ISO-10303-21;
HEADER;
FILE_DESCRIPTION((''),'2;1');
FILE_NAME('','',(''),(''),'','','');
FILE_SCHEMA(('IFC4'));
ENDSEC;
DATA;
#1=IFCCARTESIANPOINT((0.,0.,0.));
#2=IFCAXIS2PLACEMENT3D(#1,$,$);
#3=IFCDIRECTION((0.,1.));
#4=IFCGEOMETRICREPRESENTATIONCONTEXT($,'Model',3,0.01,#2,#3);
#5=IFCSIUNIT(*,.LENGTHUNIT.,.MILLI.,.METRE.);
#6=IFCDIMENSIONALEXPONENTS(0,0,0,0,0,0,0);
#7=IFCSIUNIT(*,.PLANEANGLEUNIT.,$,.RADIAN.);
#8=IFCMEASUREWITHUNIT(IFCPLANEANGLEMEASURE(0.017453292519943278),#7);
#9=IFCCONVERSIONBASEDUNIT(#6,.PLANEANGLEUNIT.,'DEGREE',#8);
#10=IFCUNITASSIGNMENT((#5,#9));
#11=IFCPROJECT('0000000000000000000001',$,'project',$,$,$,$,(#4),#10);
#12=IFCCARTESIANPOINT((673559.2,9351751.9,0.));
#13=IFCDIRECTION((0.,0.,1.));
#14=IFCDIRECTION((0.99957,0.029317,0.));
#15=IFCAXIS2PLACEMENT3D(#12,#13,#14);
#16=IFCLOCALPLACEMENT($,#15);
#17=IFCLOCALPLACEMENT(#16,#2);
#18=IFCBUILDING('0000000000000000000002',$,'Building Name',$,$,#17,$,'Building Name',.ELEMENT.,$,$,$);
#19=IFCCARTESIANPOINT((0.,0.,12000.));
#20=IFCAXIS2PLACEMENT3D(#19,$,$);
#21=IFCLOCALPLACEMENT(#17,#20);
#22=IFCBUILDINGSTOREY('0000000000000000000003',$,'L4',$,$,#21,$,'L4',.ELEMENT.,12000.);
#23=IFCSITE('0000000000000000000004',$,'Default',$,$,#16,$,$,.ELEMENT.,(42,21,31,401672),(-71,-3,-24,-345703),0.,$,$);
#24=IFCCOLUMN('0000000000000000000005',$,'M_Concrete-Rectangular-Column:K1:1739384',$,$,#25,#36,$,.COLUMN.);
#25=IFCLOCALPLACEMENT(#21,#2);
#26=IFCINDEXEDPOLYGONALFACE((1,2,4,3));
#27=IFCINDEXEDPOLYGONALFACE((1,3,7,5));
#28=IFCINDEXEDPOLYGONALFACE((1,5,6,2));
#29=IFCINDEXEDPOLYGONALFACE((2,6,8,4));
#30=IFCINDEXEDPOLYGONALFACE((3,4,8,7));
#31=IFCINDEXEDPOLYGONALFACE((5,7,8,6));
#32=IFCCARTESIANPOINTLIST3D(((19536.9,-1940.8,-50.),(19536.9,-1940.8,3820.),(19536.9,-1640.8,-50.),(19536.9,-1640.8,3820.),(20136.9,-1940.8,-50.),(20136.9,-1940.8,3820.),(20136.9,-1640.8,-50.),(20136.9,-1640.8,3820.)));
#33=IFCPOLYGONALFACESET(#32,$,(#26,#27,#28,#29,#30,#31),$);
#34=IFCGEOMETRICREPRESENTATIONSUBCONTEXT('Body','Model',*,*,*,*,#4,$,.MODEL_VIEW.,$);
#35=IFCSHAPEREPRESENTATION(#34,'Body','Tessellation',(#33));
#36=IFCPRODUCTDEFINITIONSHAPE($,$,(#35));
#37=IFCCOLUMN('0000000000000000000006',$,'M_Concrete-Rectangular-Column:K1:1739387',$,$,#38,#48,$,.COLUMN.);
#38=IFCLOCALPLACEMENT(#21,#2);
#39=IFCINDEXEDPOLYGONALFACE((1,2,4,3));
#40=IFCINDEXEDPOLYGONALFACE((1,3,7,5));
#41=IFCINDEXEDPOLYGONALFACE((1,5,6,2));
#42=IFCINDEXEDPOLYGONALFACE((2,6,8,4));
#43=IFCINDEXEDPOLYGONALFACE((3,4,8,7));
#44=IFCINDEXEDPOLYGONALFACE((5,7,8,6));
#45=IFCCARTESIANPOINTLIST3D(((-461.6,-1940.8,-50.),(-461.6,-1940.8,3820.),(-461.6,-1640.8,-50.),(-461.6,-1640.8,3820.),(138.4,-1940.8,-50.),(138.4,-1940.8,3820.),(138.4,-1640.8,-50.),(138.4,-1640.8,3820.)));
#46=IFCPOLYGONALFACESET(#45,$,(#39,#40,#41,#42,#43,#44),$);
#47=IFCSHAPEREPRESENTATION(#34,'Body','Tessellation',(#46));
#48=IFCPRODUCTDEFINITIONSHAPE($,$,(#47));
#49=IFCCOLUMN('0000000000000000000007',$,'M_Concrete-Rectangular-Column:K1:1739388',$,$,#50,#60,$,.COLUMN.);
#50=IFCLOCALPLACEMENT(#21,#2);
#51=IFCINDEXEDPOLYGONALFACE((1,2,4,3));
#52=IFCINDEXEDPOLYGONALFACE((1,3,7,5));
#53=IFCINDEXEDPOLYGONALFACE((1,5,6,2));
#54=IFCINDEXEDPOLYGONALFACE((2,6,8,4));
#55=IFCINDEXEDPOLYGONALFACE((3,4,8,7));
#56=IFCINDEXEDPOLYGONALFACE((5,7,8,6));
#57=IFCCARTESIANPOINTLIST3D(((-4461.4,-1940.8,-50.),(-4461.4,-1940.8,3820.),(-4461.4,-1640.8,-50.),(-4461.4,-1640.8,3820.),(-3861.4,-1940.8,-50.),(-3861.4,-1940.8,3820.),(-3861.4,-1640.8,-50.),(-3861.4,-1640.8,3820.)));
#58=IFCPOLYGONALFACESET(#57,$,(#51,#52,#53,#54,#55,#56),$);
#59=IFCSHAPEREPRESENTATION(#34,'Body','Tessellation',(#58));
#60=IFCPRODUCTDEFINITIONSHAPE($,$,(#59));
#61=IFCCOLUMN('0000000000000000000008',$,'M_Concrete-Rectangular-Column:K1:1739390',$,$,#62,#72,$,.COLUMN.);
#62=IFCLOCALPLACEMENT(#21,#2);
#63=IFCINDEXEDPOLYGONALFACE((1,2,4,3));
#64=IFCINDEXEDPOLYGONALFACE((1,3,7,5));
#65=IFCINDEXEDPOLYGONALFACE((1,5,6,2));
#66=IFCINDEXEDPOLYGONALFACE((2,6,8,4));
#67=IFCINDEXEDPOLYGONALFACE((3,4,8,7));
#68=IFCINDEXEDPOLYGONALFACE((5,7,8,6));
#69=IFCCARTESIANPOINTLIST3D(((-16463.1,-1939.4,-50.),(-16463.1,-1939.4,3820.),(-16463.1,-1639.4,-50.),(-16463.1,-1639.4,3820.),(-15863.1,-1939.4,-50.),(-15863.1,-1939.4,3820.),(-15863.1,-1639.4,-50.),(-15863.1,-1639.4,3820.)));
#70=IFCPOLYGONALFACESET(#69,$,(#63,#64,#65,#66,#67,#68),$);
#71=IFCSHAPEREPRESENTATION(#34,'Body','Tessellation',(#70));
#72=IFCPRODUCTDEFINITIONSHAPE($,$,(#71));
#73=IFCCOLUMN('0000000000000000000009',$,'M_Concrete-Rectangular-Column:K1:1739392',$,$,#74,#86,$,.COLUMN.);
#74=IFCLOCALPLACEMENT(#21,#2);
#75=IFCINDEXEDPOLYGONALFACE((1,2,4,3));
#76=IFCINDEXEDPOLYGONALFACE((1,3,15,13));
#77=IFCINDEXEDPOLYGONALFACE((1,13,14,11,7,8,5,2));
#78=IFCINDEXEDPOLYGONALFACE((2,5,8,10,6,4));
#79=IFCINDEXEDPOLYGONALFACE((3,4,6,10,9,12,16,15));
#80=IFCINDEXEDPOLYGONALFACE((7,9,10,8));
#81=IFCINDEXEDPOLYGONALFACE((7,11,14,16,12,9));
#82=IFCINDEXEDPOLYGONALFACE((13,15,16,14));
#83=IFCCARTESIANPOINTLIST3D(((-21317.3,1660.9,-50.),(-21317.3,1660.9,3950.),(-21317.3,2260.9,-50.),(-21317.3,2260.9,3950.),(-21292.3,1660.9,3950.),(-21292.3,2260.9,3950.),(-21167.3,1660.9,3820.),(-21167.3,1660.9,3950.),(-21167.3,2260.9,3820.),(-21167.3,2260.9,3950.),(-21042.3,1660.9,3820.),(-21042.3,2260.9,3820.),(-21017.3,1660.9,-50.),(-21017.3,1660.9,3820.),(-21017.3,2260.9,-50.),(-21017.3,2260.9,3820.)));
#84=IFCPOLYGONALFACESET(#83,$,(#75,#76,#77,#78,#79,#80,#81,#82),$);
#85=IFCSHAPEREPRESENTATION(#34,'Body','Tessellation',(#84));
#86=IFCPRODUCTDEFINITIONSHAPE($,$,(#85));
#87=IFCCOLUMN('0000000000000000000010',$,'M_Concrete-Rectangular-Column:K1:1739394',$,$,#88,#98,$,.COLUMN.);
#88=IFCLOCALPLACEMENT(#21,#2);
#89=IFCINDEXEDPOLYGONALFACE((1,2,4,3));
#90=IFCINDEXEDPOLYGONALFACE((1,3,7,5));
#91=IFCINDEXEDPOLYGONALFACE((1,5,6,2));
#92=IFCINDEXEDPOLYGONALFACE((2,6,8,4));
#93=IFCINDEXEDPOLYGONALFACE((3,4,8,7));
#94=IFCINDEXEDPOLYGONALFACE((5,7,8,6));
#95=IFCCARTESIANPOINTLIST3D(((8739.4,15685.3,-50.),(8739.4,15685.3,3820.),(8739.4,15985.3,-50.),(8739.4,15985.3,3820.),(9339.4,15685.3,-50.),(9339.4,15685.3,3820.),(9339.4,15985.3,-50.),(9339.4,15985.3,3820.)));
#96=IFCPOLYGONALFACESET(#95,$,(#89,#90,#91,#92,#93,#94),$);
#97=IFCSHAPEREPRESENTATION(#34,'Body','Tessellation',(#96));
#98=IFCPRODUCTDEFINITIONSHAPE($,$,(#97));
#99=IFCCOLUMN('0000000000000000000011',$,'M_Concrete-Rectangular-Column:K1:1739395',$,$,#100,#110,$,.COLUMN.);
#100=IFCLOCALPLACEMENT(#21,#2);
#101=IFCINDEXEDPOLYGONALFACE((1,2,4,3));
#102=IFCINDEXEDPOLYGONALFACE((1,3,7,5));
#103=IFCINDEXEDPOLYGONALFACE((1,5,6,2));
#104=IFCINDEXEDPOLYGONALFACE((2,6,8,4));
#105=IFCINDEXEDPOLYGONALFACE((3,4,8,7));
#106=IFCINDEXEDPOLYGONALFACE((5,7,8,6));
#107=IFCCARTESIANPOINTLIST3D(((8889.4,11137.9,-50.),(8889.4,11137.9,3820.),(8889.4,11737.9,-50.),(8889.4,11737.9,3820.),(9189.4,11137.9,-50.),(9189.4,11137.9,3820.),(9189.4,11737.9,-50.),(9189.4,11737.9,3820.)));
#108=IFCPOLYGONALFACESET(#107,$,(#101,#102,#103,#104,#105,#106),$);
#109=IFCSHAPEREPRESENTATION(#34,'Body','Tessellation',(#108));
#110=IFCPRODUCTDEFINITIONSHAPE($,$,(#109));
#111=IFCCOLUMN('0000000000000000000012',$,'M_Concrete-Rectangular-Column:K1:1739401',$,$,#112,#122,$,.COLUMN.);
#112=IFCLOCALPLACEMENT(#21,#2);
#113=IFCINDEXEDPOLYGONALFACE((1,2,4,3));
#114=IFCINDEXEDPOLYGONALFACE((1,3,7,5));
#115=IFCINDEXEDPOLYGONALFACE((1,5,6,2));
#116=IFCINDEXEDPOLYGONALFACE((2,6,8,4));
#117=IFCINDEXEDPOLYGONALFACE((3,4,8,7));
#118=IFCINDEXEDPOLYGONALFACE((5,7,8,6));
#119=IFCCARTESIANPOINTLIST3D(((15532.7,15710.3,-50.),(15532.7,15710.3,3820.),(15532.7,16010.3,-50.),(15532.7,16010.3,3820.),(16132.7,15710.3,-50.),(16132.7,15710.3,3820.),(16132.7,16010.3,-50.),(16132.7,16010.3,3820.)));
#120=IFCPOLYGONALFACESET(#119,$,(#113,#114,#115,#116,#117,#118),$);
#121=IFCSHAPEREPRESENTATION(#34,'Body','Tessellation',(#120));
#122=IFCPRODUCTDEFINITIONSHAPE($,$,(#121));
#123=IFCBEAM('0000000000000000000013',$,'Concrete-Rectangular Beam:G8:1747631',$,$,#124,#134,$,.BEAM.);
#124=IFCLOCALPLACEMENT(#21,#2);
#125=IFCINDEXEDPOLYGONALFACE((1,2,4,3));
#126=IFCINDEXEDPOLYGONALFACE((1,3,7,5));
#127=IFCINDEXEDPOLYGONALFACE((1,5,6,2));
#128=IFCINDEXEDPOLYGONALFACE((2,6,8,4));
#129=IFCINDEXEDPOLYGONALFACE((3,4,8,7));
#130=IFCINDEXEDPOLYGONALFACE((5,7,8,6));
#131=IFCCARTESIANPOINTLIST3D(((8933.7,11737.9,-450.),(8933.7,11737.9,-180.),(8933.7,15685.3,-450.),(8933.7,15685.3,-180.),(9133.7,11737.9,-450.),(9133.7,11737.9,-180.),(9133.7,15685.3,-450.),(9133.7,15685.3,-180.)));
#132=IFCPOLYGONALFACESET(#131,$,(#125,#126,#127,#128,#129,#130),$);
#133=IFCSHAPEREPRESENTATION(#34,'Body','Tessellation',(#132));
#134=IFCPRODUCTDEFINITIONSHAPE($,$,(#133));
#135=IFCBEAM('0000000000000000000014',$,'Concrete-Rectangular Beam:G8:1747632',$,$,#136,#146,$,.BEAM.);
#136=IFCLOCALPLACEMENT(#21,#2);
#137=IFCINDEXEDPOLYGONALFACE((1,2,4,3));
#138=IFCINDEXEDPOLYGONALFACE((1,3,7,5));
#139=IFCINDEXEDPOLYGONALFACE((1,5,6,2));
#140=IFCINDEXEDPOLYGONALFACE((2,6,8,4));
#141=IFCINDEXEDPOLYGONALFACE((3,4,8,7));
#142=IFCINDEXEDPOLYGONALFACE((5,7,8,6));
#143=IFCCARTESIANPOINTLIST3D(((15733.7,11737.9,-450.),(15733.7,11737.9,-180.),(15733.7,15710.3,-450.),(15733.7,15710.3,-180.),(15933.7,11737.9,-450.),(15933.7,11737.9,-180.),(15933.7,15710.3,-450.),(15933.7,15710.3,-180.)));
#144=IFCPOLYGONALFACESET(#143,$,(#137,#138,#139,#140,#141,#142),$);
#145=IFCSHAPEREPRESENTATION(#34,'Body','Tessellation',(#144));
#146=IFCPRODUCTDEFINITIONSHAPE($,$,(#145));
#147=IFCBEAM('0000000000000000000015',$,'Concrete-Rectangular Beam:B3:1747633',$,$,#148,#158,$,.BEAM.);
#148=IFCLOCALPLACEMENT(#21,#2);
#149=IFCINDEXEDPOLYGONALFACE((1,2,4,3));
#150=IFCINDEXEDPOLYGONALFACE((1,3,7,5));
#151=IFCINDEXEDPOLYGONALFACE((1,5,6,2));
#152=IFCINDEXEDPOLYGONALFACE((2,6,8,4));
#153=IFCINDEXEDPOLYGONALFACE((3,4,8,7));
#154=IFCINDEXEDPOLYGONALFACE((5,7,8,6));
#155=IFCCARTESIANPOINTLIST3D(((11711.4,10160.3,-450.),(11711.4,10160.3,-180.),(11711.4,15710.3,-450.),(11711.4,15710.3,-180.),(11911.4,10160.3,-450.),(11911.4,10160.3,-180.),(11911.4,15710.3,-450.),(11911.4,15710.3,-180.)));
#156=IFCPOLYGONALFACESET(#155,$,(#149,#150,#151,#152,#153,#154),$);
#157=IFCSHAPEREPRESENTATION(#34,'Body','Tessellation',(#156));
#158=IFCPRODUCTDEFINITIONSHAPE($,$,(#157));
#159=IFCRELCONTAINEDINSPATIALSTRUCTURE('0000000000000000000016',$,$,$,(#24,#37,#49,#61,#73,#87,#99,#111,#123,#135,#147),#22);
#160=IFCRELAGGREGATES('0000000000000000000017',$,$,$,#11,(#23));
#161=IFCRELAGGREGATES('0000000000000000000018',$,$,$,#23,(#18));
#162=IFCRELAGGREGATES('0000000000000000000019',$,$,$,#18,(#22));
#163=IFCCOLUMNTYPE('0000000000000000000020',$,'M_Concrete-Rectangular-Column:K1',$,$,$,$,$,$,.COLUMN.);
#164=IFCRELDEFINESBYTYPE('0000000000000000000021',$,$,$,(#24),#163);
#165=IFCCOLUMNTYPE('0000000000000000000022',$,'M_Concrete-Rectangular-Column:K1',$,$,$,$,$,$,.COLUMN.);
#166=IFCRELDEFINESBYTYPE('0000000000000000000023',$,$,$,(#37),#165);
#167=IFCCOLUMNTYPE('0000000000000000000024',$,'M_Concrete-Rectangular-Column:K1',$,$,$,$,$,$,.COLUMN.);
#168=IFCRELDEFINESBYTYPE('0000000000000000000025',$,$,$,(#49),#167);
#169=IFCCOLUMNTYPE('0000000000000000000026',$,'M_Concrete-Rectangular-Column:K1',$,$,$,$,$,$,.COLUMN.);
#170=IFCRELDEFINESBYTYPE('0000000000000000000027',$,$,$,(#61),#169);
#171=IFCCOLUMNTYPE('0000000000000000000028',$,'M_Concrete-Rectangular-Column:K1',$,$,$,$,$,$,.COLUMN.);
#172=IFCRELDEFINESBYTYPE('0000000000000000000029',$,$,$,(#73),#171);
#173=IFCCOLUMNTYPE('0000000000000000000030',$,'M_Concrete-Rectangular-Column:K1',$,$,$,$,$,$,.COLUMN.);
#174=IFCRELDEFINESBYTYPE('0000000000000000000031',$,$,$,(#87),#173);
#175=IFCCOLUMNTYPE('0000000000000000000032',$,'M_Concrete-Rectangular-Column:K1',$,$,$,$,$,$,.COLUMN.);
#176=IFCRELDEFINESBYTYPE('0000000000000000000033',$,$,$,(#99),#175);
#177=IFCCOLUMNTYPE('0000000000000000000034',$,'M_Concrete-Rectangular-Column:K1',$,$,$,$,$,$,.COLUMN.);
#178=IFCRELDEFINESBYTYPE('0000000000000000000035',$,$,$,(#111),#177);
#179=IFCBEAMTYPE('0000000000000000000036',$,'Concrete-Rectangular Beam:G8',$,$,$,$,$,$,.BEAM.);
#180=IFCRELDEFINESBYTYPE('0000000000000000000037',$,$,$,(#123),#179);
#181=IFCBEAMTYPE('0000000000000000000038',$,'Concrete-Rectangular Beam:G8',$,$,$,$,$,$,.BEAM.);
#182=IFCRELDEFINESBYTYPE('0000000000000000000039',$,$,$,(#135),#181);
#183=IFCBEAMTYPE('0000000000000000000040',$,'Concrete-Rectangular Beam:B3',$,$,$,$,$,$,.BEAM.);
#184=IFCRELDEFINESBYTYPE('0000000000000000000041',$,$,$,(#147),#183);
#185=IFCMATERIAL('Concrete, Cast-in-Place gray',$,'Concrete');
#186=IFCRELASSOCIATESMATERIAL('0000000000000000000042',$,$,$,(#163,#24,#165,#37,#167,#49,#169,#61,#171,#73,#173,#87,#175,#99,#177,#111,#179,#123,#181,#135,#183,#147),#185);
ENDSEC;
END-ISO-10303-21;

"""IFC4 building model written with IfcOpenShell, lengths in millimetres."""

from ifc_helpers import new_model, entity, si_unit, converted_unit, direction, frame, origin, place, context, subcontext, project, spatial, indexed_curve, outline, extrude, source, transform, mapped, material, type_object, type_shapes, element, save


model = new_model("IFC4")

# Units and contexts
model_context = context("Model", 3, precision=0.01, world=origin(), true_north=direction((0.0, 1.0)))
body_context = subcontext(model_context, "Body", "Model", "MODEL_VIEW")
ifc_project = project(units=[si_unit("LENGTHUNIT", "METRE", prefix="MILLI"), converted_unit("PLANEANGLEUNIT", "DEGREE", entity("IfcPlaneAngleMeasure", 0.017453292519943278), si_unit("PLANEANGLEUNIT", "RADIAN"), dimensions=[0, 0, 0, 0, 0, 0, 0])], contexts=[model_context])

# Site, building, storey
site_placement = place(None, frame((673559.2, 9351751.9, 0.0), z_axis=(0.0, 0.0, 1.0), x_axis=(0.99957, 0.029317, 0.0)))
site = spatial("IfcSite", under=ifc_project, at=site_placement, Name="Default", CompositionType="ELEMENT", RefLatitude=(42, 21, 31, 401672), RefLongitude=(-71, -3, -24, -345703), RefElevation=0.0)
building_placement = place(site_placement, origin())
building = spatial("IfcBuilding", under=site, at=building_placement, Name="Building Name", LongName="Building Name", CompositionType="ELEMENT")
storey_placement = place(building_placement, frame((0.0, 0.0, 12000.0)))
storey = spatial("IfcBuildingStorey", under=building, at=storey_placement, Name="L4", LongName="L4", CompositionType="ELEMENT", Elevation=12000.0)

# Columns
ifc_material = material(Name="Concrete, Cast-in-Place gray", Category="Concrete")
column_type_1 = type_object("IfcColumnType", Name="M_Concrete-Rectangular-Column:K1", PredefinedType="COLUMN", material=ifc_material)
shared_shape_1 = source(origin(), body_context, "Body", "SweptSolid", [
    extrude(outline(indexed_curve([(-150.0, -300.0), (150.0, -300.0), (150.0, 300.0), (-150.0, 300.0), (-150.0, -300.0)], self_intersect=False)), frame((19836.9, -1790.8, 11950.0), z_axis=(0.0, 0.0, 1.0), x_axis=(0.0, -1.0, 0.0)), (0.0, 0.0, 1.0), 3870.0),
])
type_shapes(column_type_1, [shared_shape_1])
column_1_placement = place(storey_placement, frame((0.0, 0.0, -12000.0)))
element("IfcColumn", 1, at=column_1_placement, inside=storey, type_object=column_type_1, material=ifc_material, Name="M_Concrete-Rectangular-Column:K1:1739384", PredefinedType="COLUMN", context=body_context, shape_type="MappedRepresentation", body=[
    mapped(shared_shape_1, transform((0.0, 0.0, 0.0), scale=1.0)),
])
column_type_2 = type_object("IfcColumnType", Name="M_Concrete-Rectangular-Column:K1", PredefinedType="COLUMN", material=ifc_material)
shared_shape_2 = source(origin(), body_context, "Body", "SweptSolid", [
    extrude(outline(indexed_curve([(-150.0, -300.0), (150.0, -300.0), (150.0, 300.0), (-150.0, 300.0), (-150.0, -300.0)], self_intersect=False)), frame((-161.6, -1790.8, 11950.0), z_axis=(0.0, 0.0, 1.0), x_axis=(0.0, -1.0, 0.0)), (0.0, 0.0, 1.0), 3870.0),
])
type_shapes(column_type_2, [shared_shape_2])
column_2_placement = place(storey_placement, frame((0.0, 0.0, -12000.0)))
element("IfcColumn", 2, at=column_2_placement, inside=storey, type_object=column_type_2, material=ifc_material, Name="M_Concrete-Rectangular-Column:K1:1739387", PredefinedType="COLUMN", context=body_context, shape_type="MappedRepresentation", body=[
    mapped(shared_shape_2, transform((0.0, 0.0, 0.0), scale=1.0)),
])
column_type_3 = type_object("IfcColumnType", Name="M_Concrete-Rectangular-Column:K1", PredefinedType="COLUMN", material=ifc_material)
shared_shape_3 = source(origin(), body_context, "Body", "SweptSolid", [
    extrude(outline(indexed_curve([(-150.0, -300.0), (150.0, -300.0), (150.0, 300.0), (-150.0, 300.0), (-150.0, -300.0)], self_intersect=False)), frame((-4161.4, -1790.8, 11950.0), z_axis=(0.0, 0.0, 1.0), x_axis=(0.0, -1.0, 0.0)), (0.0, 0.0, 1.0), 3870.0),
])
type_shapes(column_type_3, [shared_shape_3])
column_3_placement = place(storey_placement, frame((0.0, 0.0, -12000.0)))
element("IfcColumn", 3, at=column_3_placement, inside=storey, type_object=column_type_3, material=ifc_material, Name="M_Concrete-Rectangular-Column:K1:1739388", PredefinedType="COLUMN", context=body_context, shape_type="MappedRepresentation", body=[
    mapped(shared_shape_3, transform((0.0, 0.0, 0.0), scale=1.0)),
])
column_type_4 = type_object("IfcColumnType", Name="M_Concrete-Rectangular-Column:K1", PredefinedType="COLUMN", material=ifc_material)
shared_shape_4 = source(origin(), body_context, "Body", "SweptSolid", [
    extrude(outline(indexed_curve([(-150.0, -300.0), (150.0, -300.0), (150.0, 300.0), (-150.0, 300.0), (-150.0, -300.0)], self_intersect=False)), frame((-16163.1, -1789.4, 11950.0), z_axis=(0.0, 0.0, 1.0), x_axis=(0.0, -1.0, 0.0)), (0.0, 0.0, 1.0), 3870.0),
])
type_shapes(column_type_4, [shared_shape_4])
column_4_placement = place(storey_placement, frame((0.0, 0.0, -12000.0)))
element("IfcColumn", 4, at=column_4_placement, inside=storey, type_object=column_type_4, material=ifc_material, Name="M_Concrete-Rectangular-Column:K1:1739390", PredefinedType="COLUMN", context=body_context, shape_type="MappedRepresentation", body=[
    mapped(shared_shape_4, transform((0.0, 0.0, 0.0), scale=1.0)),
])
column_type_5 = type_object("IfcColumnType", Name="M_Concrete-Rectangular-Column:K1", PredefinedType="COLUMN", material=ifc_material)
shared_shape_5 = source(origin(), body_context, "Body", "SweptSolid", [
    extrude(outline(indexed_curve([(-2951.3, -150.0), (1048.7, -150.0), (1048.7, -125.0), (1048.7, 0.0), (918.7, 0.0), (918.7, 125.0), (918.7, 150.0), (-2951.3, 150.0), (-2951.3, -150.0)], self_intersect=False)), frame((-21167.3, 1660.9, 14901.3), z_axis=(0.0, 1.0, 0.0), x_axis=(0.0, 0.0, 1.0)), (0.0, 0.0, 1.0), 600.0),
])
type_shapes(column_type_5, [shared_shape_5])
column_5_placement = place(storey_placement, frame((0.0, 0.0, -12000.0)))
element("IfcColumn", 5, at=column_5_placement, inside=storey, type_object=column_type_5, material=ifc_material, Name="M_Concrete-Rectangular-Column:K1:1739392", PredefinedType="COLUMN", context=body_context, shape_type="MappedRepresentation", body=[
    mapped(shared_shape_5, transform((0.0, 0.0, 0.0), scale=1.0)),
])
column_type_6 = type_object("IfcColumnType", Name="M_Concrete-Rectangular-Column:K1", PredefinedType="COLUMN", material=ifc_material)
shared_shape_6 = source(origin(), body_context, "Body", "SweptSolid", [
    extrude(outline(indexed_curve([(-150.0, -300.0), (150.0, -300.0), (150.0, 300.0), (-150.0, 300.0), (-150.0, -300.0)], self_intersect=False)), frame((9039.4, 15835.3, 11950.0), z_axis=(0.0, 0.0, 1.0), x_axis=(0.0, -1.0, 0.0)), (0.0, 0.0, 1.0), 3870.0),
])
type_shapes(column_type_6, [shared_shape_6])
column_6_placement = place(storey_placement, frame((0.0, 0.0, -12000.0)))
element("IfcColumn", 6, at=column_6_placement, inside=storey, type_object=column_type_6, material=ifc_material, Name="M_Concrete-Rectangular-Column:K1:1739394", PredefinedType="COLUMN", context=body_context, shape_type="MappedRepresentation", body=[
    mapped(shared_shape_6, transform((0.0, 0.0, 0.0), scale=1.0)),
])
column_type_7 = type_object("IfcColumnType", Name="M_Concrete-Rectangular-Column:K1", PredefinedType="COLUMN", material=ifc_material)
shared_shape_7 = source(origin(), body_context, "Body", "SweptSolid", [
    extrude(outline(indexed_curve([(-1935.0, -300.0), (1935.0, -300.0), (1935.0, 300.0), (-1935.0, 300.0), (-1935.0, -300.0)], self_intersect=False)), frame((8889.4, 11437.9, 13885.0), z_axis=(1.0, 0.0, 0.0), x_axis=(0.0, 0.0, 1.0)), (0.0, 0.0, 1.0), 300.0),
])
type_shapes(column_type_7, [shared_shape_7])
column_7_placement = place(storey_placement, frame((0.0, 0.0, -12000.0)))
element("IfcColumn", 7, at=column_7_placement, inside=storey, type_object=column_type_7, material=ifc_material, Name="M_Concrete-Rectangular-Column:K1:1739395", PredefinedType="COLUMN", context=body_context, shape_type="MappedRepresentation", body=[
    mapped(shared_shape_7, transform((0.0, 0.0, 0.0), scale=1.0)),
])
column_type_8 = type_object("IfcColumnType", Name="M_Concrete-Rectangular-Column:K1", PredefinedType="COLUMN", material=ifc_material)
shared_shape_8 = source(origin(), body_context, "Body", "SweptSolid", [
    extrude(outline(indexed_curve([(-150.0, -300.0), (150.0, -300.0), (150.0, 300.0), (-150.0, 300.0), (-150.0, -300.0)], self_intersect=False)), frame((15832.7, 15860.3, 11950.0), z_axis=(0.0, 0.0, 1.0), x_axis=(0.0, -1.0, 0.0)), (0.0, 0.0, 1.0), 3870.0),
])
type_shapes(column_type_8, [shared_shape_8])
column_8_placement = place(storey_placement, frame((0.0, 0.0, -12000.0)))
element("IfcColumn", 8, at=column_8_placement, inside=storey, type_object=column_type_8, material=ifc_material, Name="M_Concrete-Rectangular-Column:K1:1739401", PredefinedType="COLUMN", context=body_context, shape_type="MappedRepresentation", body=[
    mapped(shared_shape_8, transform((0.0, 0.0, 0.0), scale=1.0)),
])

# Beams
beam_type_1 = type_object("IfcBeamType", Name="Concrete-Rectangular Beam:G8", PredefinedType="BEAM", material=ifc_material)
shared_shape_9 = source(origin(), body_context, "Body", "SweptSolid", [
    extrude(outline(indexed_curve([(-100.0, -135.0), (100.0, -135.0), (100.0, 135.0), (-100.0, 135.0), (-100.0, -135.0)], self_intersect=False)), frame((9033.7, 15685.3, 11685.0), z_axis=(0.0, -1.0, 0.0), x_axis=(-1.0, 0.0, 0.0)), (0.0, 0.0, 1.0), 3947.4),
])
type_shapes(beam_type_1, [shared_shape_9])
beam_1_placement = place(storey_placement, frame((0.0, 0.0, -12000.0)))
element("IfcBeam", 9, at=beam_1_placement, inside=storey, type_object=beam_type_1, material=ifc_material, Name="Concrete-Rectangular Beam:G8:1747631", PredefinedType="BEAM", context=body_context, shape_type="MappedRepresentation", body=[
    mapped(shared_shape_9, transform((0.0, 0.0, 0.0), scale=1.0)),
])
beam_type_2 = type_object("IfcBeamType", Name="Concrete-Rectangular Beam:G8", PredefinedType="BEAM", material=ifc_material)
shared_shape_10 = source(origin(), body_context, "Body", "SweptSolid", [
    extrude(outline(indexed_curve([(-100.0, -135.0), (100.0, -135.0), (100.0, 135.0), (-100.0, 135.0), (-100.0, -135.0)], self_intersect=False)), frame((15833.7, 15710.3, 11685.0), z_axis=(0.0, -1.0, 0.0), x_axis=(-1.0, 0.0, 0.0)), (0.0, 0.0, 1.0), 3972.4),
])
type_shapes(beam_type_2, [shared_shape_10])
beam_2_placement = place(storey_placement, frame((0.0, 0.0, -12000.0)))
element("IfcBeam", 10, at=beam_2_placement, inside=storey, type_object=beam_type_2, material=ifc_material, Name="Concrete-Rectangular Beam:G8:1747632", PredefinedType="BEAM", context=body_context, shape_type="MappedRepresentation", body=[
    mapped(shared_shape_10, transform((0.0, 0.0, 0.0), scale=1.0)),
])
beam_type_3 = type_object("IfcBeamType", Name="Concrete-Rectangular Beam:B3", PredefinedType="BEAM", material=ifc_material)
shared_shape_11 = source(origin(), body_context, "Body", "SweptSolid", [
    extrude(outline(indexed_curve([(-100.0, -135.0), (100.0, -135.0), (100.0, 135.0), (-100.0, 135.0), (-100.0, -135.0)], self_intersect=False)), frame((11811.4, 15710.3, 11685.0), z_axis=(0.0, -1.0, 0.0), x_axis=(-1.0, 0.0, 0.0)), (0.0, 0.0, 1.0), 5550.0),
])
type_shapes(beam_type_3, [shared_shape_11])
beam_3_placement = place(storey_placement, frame((0.0, 0.0, -12000.0)))
element("IfcBeam", 11, at=beam_3_placement, inside=storey, type_object=beam_type_3, material=ifc_material, Name="Concrete-Rectangular Beam:B3:1747633", PredefinedType="BEAM", context=body_context, shape_type="MappedRepresentation", body=[
    mapped(shared_shape_11, transform((0.0, 0.0, 0.0), scale=1.0)),
])

save(model, "model.ifc")
